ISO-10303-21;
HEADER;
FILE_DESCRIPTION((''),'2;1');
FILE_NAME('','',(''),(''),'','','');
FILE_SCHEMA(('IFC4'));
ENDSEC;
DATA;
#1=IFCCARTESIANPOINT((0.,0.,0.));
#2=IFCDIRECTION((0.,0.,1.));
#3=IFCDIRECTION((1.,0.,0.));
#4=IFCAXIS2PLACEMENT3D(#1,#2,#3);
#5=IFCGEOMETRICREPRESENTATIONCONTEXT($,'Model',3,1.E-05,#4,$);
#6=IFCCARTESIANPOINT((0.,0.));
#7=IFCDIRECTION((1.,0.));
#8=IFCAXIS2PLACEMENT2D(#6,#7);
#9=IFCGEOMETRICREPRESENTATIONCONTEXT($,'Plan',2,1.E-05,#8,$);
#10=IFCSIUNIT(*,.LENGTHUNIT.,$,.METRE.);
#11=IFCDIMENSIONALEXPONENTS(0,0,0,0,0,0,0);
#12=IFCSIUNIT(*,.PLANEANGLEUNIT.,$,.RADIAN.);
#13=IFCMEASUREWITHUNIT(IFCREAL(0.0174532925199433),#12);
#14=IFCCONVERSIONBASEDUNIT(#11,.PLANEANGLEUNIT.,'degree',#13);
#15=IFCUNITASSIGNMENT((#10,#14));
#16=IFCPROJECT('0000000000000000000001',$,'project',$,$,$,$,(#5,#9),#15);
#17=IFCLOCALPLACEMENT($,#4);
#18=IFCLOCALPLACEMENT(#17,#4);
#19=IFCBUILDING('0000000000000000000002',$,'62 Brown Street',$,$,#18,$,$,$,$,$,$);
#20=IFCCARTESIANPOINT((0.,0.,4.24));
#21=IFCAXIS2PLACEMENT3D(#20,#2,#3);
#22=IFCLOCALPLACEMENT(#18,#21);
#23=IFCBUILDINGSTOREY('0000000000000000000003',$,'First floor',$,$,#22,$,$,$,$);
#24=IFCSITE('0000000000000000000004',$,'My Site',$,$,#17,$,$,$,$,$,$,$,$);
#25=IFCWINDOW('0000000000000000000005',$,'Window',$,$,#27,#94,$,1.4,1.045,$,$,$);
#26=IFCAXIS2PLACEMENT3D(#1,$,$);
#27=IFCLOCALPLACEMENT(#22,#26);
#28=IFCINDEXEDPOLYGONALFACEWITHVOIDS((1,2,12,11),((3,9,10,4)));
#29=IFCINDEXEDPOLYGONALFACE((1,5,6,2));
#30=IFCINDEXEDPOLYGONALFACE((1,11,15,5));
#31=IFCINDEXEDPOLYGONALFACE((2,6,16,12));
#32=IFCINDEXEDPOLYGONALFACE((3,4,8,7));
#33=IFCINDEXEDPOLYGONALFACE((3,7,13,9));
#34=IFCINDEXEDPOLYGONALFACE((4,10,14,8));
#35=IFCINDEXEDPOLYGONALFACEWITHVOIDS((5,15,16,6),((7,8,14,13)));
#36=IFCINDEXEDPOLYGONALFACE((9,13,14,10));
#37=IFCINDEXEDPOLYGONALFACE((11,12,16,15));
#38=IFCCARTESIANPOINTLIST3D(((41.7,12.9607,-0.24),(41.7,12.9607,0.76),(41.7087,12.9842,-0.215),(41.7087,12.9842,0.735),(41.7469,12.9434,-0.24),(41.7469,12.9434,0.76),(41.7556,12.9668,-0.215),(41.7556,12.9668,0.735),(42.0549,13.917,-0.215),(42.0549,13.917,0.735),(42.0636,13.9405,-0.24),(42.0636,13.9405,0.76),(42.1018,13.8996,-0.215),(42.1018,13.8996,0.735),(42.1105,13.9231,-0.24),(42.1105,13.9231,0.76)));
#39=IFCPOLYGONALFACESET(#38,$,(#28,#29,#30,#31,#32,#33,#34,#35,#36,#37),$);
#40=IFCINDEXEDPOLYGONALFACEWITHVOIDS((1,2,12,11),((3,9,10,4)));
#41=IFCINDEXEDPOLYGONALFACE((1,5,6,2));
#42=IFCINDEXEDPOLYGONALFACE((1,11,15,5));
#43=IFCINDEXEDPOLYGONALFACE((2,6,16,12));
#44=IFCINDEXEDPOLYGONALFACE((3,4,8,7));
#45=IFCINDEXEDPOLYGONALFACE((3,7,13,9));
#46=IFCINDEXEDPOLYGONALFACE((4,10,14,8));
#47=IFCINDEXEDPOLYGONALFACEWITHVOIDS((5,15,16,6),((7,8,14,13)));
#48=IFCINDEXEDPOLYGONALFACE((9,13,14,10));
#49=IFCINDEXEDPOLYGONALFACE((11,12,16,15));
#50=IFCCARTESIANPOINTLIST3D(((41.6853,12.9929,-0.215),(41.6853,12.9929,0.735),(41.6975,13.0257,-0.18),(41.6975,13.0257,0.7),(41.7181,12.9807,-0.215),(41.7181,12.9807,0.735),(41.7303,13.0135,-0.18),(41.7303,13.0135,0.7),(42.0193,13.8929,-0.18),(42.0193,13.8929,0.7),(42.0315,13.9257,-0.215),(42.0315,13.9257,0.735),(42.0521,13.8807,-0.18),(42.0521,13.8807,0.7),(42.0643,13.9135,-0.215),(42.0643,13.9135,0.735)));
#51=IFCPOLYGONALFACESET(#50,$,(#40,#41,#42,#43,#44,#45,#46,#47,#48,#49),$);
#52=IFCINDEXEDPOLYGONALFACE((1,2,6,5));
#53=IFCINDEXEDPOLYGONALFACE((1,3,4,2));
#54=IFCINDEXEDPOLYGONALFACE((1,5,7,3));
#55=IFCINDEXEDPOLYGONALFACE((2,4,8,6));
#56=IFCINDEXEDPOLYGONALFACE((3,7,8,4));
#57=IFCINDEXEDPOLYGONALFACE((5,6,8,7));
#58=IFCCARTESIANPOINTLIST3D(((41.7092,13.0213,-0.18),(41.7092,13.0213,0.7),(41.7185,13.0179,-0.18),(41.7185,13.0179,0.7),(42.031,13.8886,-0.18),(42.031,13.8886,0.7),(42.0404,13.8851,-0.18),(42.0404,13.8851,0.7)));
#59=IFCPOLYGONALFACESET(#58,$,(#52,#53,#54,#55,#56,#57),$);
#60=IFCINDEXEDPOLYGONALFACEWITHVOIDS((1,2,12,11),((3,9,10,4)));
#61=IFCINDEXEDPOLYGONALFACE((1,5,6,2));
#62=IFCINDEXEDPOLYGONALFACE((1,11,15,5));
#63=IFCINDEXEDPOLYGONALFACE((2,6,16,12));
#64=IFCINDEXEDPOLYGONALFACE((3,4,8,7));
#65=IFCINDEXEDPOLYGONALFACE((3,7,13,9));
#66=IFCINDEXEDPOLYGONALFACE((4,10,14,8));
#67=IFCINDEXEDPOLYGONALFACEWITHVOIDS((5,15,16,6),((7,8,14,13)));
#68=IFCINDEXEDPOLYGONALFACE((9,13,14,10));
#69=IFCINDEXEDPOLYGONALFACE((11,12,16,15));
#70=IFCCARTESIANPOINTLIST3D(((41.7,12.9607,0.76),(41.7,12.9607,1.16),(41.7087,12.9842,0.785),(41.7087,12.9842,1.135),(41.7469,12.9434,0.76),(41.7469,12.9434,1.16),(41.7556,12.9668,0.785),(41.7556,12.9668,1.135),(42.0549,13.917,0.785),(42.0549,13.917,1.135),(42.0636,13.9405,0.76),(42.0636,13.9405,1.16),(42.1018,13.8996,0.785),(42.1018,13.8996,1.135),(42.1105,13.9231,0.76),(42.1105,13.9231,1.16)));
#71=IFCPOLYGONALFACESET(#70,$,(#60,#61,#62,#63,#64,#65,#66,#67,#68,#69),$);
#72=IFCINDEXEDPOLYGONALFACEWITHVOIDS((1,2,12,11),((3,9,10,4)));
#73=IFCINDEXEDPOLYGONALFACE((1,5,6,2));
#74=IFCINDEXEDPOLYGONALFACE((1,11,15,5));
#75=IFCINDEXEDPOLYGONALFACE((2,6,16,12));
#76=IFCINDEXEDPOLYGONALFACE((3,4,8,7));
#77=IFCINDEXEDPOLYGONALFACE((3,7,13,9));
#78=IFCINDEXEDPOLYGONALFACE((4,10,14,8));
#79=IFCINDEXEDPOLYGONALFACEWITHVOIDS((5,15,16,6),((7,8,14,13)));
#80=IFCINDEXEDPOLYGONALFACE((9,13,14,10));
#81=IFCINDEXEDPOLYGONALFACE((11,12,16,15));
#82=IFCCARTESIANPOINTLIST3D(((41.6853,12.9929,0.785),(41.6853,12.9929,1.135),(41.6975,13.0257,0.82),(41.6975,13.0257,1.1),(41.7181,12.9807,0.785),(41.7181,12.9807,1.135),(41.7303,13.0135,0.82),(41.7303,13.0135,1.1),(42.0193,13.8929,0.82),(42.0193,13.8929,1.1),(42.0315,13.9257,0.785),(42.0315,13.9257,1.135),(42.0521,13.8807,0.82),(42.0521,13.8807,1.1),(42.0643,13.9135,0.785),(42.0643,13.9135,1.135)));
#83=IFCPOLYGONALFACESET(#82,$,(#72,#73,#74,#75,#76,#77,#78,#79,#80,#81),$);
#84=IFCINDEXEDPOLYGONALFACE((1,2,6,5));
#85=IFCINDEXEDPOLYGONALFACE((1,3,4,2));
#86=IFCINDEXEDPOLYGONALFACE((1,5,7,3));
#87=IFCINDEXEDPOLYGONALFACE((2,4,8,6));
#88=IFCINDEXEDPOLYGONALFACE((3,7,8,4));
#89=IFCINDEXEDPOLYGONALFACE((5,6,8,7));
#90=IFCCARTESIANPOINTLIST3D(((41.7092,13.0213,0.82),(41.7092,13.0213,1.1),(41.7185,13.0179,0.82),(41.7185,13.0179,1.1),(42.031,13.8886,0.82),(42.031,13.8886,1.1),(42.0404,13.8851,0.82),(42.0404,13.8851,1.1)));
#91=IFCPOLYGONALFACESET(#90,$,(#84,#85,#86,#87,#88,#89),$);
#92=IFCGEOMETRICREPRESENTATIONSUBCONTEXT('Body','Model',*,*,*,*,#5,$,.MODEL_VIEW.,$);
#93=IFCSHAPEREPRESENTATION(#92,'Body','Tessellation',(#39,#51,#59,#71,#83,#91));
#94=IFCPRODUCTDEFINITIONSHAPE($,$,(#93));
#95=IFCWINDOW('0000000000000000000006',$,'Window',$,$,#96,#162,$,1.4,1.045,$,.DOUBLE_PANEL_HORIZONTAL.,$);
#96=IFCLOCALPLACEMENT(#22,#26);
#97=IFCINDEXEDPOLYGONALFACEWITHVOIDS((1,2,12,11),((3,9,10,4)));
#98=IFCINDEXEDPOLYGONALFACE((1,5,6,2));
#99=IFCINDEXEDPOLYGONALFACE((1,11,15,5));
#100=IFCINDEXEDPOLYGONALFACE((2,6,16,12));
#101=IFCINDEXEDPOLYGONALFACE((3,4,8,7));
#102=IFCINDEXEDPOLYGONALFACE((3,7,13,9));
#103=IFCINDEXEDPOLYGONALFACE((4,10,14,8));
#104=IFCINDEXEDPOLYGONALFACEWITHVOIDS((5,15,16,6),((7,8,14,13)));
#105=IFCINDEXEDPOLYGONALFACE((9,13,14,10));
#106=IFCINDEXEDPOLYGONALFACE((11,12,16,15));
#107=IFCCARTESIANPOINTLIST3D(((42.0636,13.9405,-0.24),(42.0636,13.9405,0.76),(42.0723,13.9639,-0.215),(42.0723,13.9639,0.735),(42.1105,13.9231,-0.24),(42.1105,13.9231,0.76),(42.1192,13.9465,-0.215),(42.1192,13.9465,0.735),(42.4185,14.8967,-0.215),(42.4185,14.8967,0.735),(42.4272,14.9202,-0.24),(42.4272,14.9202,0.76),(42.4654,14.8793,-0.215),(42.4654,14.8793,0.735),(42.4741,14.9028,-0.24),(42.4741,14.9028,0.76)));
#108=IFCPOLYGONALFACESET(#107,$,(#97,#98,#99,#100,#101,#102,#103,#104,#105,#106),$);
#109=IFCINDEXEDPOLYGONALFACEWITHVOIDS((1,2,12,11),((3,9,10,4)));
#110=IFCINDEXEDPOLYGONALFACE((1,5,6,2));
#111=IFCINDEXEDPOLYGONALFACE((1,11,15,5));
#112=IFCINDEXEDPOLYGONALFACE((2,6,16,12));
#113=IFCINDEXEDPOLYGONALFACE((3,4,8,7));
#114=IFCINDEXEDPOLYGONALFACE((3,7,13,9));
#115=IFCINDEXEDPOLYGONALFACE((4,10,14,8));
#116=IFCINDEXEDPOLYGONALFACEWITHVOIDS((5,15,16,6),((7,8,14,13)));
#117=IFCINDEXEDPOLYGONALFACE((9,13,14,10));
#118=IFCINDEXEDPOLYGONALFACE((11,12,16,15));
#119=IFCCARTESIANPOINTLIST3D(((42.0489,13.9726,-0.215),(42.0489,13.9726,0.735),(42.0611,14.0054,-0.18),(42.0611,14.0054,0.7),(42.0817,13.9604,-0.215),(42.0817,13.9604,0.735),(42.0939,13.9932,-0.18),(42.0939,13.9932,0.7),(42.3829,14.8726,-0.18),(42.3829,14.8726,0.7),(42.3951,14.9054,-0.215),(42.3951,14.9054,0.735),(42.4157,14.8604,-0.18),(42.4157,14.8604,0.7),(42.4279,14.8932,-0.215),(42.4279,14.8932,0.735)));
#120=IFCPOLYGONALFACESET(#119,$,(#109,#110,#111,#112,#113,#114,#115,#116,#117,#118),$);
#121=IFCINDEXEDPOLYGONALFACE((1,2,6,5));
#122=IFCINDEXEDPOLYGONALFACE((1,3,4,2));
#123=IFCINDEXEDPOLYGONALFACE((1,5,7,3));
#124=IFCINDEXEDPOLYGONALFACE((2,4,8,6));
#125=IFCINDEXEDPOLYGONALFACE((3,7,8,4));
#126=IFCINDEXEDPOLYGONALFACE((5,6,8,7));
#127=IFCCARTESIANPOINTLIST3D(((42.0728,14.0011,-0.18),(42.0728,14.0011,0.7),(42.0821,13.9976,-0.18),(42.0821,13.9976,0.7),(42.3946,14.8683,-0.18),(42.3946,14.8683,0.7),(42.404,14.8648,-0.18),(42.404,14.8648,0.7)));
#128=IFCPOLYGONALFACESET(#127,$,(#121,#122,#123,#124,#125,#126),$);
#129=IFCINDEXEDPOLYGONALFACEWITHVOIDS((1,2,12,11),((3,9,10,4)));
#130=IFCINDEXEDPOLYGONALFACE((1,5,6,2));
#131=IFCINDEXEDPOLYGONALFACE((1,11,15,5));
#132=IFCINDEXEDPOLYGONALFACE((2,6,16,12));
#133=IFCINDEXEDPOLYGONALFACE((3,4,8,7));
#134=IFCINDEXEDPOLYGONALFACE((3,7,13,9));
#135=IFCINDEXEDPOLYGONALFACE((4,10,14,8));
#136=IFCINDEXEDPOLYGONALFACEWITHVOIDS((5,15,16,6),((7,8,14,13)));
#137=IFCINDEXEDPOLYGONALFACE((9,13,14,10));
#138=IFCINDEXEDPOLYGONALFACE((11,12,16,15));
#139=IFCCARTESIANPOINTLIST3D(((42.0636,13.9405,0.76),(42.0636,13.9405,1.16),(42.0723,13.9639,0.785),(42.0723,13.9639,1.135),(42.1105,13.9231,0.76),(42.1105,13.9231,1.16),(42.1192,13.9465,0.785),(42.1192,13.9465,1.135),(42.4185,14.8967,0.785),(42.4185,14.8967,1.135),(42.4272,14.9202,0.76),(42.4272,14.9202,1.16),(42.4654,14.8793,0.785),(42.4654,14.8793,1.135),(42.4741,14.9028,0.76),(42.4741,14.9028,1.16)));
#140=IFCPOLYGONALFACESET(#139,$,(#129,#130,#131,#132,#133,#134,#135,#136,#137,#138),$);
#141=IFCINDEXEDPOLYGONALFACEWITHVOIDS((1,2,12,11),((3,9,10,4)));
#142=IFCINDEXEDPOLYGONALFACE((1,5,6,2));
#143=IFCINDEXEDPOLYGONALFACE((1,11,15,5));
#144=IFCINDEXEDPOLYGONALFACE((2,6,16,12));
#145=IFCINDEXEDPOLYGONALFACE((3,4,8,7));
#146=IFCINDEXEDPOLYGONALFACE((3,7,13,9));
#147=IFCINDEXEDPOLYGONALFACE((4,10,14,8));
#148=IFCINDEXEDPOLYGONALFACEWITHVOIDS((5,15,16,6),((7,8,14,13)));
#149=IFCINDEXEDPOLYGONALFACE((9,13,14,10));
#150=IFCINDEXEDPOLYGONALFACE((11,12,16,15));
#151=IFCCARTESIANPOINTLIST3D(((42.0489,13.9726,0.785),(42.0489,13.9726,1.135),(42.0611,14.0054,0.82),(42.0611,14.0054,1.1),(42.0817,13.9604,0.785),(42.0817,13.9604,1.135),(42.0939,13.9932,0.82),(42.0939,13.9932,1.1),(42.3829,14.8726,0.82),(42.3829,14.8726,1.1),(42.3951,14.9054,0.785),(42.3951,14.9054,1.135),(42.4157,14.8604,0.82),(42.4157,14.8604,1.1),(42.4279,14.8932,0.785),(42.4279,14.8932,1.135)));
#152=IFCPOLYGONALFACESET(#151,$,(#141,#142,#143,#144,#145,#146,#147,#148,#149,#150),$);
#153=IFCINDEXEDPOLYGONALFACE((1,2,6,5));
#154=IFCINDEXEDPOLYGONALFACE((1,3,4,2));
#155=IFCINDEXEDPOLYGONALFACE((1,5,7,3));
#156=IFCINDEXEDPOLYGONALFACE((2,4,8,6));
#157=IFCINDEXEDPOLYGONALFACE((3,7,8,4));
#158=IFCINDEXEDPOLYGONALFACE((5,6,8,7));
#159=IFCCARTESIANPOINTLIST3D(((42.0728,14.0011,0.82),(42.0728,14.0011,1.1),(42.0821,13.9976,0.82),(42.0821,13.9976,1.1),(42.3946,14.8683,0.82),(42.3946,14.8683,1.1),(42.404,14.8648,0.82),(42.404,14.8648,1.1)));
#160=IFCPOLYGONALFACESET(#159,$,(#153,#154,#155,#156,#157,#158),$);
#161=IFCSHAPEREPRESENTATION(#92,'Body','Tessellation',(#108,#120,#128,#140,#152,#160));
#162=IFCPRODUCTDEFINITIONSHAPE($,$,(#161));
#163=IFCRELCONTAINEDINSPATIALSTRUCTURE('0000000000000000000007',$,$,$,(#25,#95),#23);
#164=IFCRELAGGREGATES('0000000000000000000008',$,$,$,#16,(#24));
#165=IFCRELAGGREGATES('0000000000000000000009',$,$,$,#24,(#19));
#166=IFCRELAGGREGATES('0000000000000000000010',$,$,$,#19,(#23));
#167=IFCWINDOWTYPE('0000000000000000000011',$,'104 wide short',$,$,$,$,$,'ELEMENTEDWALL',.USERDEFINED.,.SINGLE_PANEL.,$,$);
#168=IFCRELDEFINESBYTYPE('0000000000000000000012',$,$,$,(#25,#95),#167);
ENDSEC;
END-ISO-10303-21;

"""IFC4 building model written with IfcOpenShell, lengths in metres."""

from ifc_helpers import new_model, entity, si_unit, converted_unit, frame, origin_with_axes, origin_2d_with_axis, place, context, subcontext, project, spatial, line, indexed_curve, outline, extrude, shape, source, transform, mapped, type_object, type_shapes, element, save


model = new_model("IFC4")

# Units and contexts
model_context = context("Model", 3, precision=1e-05, world=origin_with_axes())
plan_context = context("Plan", 2, precision=1e-05, world=origin_2d_with_axis())
body_context_1 = subcontext(model_context, "Body", "Model", "MODEL_VIEW")
body_context_2 = subcontext(plan_context, "Body", "Plan", "PLAN_VIEW")
ifc_project = project(units=[si_unit("LENGTHUNIT", "METRE"), converted_unit("PLANEANGLEUNIT", "degree", entity("IfcReal", 0.0174532925199433), si_unit("PLANEANGLEUNIT", "RADIAN"), dimensions=[0, 0, 0, 0, 0, 0, 0])], contexts=[model_context, plan_context])

# Site, building, storey
site_placement = place(None, origin_with_axes())
site = spatial("IfcSite", under=ifc_project, at=site_placement, Name="My Site")
building_placement = place(site_placement, origin_with_axes())
building = spatial("IfcBuilding", under=site, at=building_placement, Name="62 Brown Street")
storey_placement = place(building_placement, frame((0.0, 0.0, 4.24), z_axis=(0.0, 0.0, 1.0), x_axis=(1.0, 0.0, 0.0)))
storey = spatial("IfcBuildingStorey", under=building, at=storey_placement, Name="First floor")

# Shared definitions
window_type_1 = type_object("IfcWindowType", Name="104 wide short", ElementType="ELEMENTEDWALL", PartitioningType="SINGLE_PANEL", PredefinedType="USERDEFINED")
shared_shape_1 = source(origin_with_axes(), body_context_1, "Body", "SweptSolid", [
    extrude(outline(indexed_curve([(0.0, 0.0), (1.045, 0.0), (1.045, 1.0), (0.0, 1.0)], segments=[line(1, 2, 3, 4, 1)]), holes=[indexed_curve([(0.025, 0.025), (1.02, 0.025), (1.02, 0.975), (0.025, 0.975)], segments=[line(1, 2, 3, 4, 1)])]), frame((0.0, 0.15, 0.0), z_axis=(0.0, -1.0, 0.0), x_axis=(1.0, 0.0, 0.0)), (0.0, 0.0, -1.0), 0.05),
    extrude(outline(indexed_curve([(0.0, 0.0), (0.995, 0.0), (0.995, 0.95), (0.0, 0.95)], segments=[line(1, 2, 3, 4, 1)]), holes=[indexed_curve([(0.035, 0.035), (0.96, 0.035), (0.96, 0.915), (0.035, 0.915)], segments=[line(1, 2, 3, 4, 1)])]), frame((0.025, 0.19, 0.025), z_axis=(0.0, -1.0, 0.0), x_axis=(1.0, 0.0, 0.0)), (0.0, 0.0, -1.0), 0.035),
    extrude(outline(indexed_curve([(0.035, 0.035), (0.96, 0.035), (0.96, 0.915), (0.035, 0.915)], segments=[line(1, 2, 3, 4, 1)])), frame((0.025, 0.2025, 0.025), z_axis=(0.0, -1.0, 0.0), x_axis=(1.0, 0.0, 0.0)), (0.0, 0.0, -1.0), 0.01),
    extrude(outline(indexed_curve([(0.0, 0.0), (1.045, 0.0), (1.045, 0.4), (0.0, 0.4)], segments=[line(1, 2, 3, 4, 1)]), holes=[indexed_curve([(0.025, 0.025), (1.02, 0.025), (1.02, 0.375), (0.025, 0.375)], segments=[line(1, 2, 3, 4, 1)])]), frame((0.0, 0.15, 1.0), z_axis=(0.0, -1.0, 0.0), x_axis=(1.0, 0.0, 0.0)), (0.0, 0.0, -1.0), 0.05),
    extrude(outline(indexed_curve([(0.0, 0.0), (0.995, 0.0), (0.995, 0.35), (0.0, 0.35)], segments=[line(1, 2, 3, 4, 1)]), holes=[indexed_curve([(0.035, 0.035), (0.96, 0.035), (0.96, 0.315), (0.035, 0.315)], segments=[line(1, 2, 3, 4, 1)])]), frame((0.025, 0.19, 1.025), z_axis=(0.0, -1.0, 0.0), x_axis=(1.0, 0.0, 0.0)), (0.0, 0.0, -1.0), 0.035),
    extrude(outline(indexed_curve([(0.035, 0.035), (0.96, 0.035), (0.96, 0.315), (0.035, 0.315)], segments=[line(1, 2, 3, 4, 1)])), frame((0.025, 0.2025, 1.025), z_axis=(0.0, -1.0, 0.0), x_axis=(1.0, 0.0, 0.0)), (0.0, 0.0, -1.0), 0.01),
])
shared_shape_2 = source(origin_with_axes(), body_context_2, "Body", "Curve2D", [
    entity("IfcIndexedPolyCurve", entity("IfcCartesianPointList2D", [[0.025, 0.15], [1.02, 0.15]])),
    entity("IfcIndexedPolyCurve", entity("IfcCartesianPointList2D", [[0.0, 0.2], [0.025, 0.2], [0.025, 0.15], [0.0, 0.15]]), [entity("IfcLineIndex", [1, 2, 3, 4, 1])]),
    entity("IfcIndexedPolyCurve", entity("IfcCartesianPointList2D", [[1.045, 0.2], [1.02, 0.2], [1.02, 0.15], [1.045, 0.15]]), [entity("IfcLineIndex", [1, 2, 3, 4, 1])]),
    entity("IfcIndexedPolyCurve", entity("IfcCartesianPointList2D", [[0.025, 0.19], [0.06, 0.19], [0.06, 0.225], [0.025, 0.225]]), [entity("IfcLineIndex", [1, 2, 3, 4, 1])]),
    entity("IfcIndexedPolyCurve", entity("IfcCartesianPointList2D", [[1.02, 0.19], [0.985, 0.19], [0.985, 0.225], [1.02, 0.225]]), [entity("IfcLineIndex", [1, 2, 3, 4, 1])]),
    entity("IfcIndexedPolyCurve", entity("IfcCartesianPointList2D", [[0.06, 0.19], [0.985, 0.19]])),
    entity("IfcIndexedPolyCurve", entity("IfcCartesianPointList2D", [[0.06, 0.225], [0.985, 0.225]])),
    entity("IfcIndexedPolyCurve", entity("IfcCartesianPointList2D", [[0.06, 0.2075], [0.985, 0.2075]])),
])
type_shapes(window_type_1, [shared_shape_1, shared_shape_2])

# Windows
for number, where, z_axis, x_axis, name in (
    (1, (41.8875, 12.8912, -0.24), (0.0, 0.0, 1.0), (0.347944, 0.937515, 0.0), "Window"),
):
    element("IfcWindow", number, at=place(storey_placement, frame(where, z_axis=z_axis, x_axis=x_axis)), inside=storey, type_object=window_type_1, Name=name, OverallHeight=1.4, OverallWidth=1.045, shapes=[
        shape(body_context_1, "Body", "MappedRepresentation", [mapped(shared_shape_1, transform((0.0, 0.0, 0.0), x_axis=(1.0, 0.0, 0.0), y_axis=(0.0, 1.0, 0.0), z_axis=(0.0, 0.0, 1.0), scale=1.0))]),
        shape(body_context_2, "Body", "MappedRepresentation", [mapped(shared_shape_2, transform((0.0, 0.0, 0.0), x_axis=(1.0, 0.0, 0.0), y_axis=(0.0, 1.0, 0.0), z_axis=(0.0, 0.0, 1.0), scale=1.0))]),
    ])
window_1_placement = place(storey_placement, frame((42.2511, 13.8709, -0.24), z_axis=(0.0, 0.0, 1.0), x_axis=(0.347944, 0.937515, 0.0)))
element("IfcWindow", 2, at=window_1_placement, inside=storey, type_object=window_type_1, Name="Window", OverallHeight=1.4, OverallWidth=1.045, PartitioningType="DOUBLE_PANEL_HORIZONTAL", shapes=[
    shape(body_context_1, "Body", "MappedRepresentation", [mapped(shared_shape_1, transform((0.0, 0.0, 0.0), x_axis=(1.0, 0.0, 0.0), y_axis=(0.0, 1.0, 0.0), z_axis=(0.0, 0.0, 1.0), scale=1.0))]),
    shape(body_context_2, "Body", "MappedRepresentation", [mapped(shared_shape_2, transform((0.0, 0.0, 0.0), x_axis=(1.0, 0.0, 0.0), y_axis=(0.0, 1.0, 0.0), z_axis=(0.0, 0.0, 1.0), scale=1.0))]),
])

save(model, "model.ifc")
